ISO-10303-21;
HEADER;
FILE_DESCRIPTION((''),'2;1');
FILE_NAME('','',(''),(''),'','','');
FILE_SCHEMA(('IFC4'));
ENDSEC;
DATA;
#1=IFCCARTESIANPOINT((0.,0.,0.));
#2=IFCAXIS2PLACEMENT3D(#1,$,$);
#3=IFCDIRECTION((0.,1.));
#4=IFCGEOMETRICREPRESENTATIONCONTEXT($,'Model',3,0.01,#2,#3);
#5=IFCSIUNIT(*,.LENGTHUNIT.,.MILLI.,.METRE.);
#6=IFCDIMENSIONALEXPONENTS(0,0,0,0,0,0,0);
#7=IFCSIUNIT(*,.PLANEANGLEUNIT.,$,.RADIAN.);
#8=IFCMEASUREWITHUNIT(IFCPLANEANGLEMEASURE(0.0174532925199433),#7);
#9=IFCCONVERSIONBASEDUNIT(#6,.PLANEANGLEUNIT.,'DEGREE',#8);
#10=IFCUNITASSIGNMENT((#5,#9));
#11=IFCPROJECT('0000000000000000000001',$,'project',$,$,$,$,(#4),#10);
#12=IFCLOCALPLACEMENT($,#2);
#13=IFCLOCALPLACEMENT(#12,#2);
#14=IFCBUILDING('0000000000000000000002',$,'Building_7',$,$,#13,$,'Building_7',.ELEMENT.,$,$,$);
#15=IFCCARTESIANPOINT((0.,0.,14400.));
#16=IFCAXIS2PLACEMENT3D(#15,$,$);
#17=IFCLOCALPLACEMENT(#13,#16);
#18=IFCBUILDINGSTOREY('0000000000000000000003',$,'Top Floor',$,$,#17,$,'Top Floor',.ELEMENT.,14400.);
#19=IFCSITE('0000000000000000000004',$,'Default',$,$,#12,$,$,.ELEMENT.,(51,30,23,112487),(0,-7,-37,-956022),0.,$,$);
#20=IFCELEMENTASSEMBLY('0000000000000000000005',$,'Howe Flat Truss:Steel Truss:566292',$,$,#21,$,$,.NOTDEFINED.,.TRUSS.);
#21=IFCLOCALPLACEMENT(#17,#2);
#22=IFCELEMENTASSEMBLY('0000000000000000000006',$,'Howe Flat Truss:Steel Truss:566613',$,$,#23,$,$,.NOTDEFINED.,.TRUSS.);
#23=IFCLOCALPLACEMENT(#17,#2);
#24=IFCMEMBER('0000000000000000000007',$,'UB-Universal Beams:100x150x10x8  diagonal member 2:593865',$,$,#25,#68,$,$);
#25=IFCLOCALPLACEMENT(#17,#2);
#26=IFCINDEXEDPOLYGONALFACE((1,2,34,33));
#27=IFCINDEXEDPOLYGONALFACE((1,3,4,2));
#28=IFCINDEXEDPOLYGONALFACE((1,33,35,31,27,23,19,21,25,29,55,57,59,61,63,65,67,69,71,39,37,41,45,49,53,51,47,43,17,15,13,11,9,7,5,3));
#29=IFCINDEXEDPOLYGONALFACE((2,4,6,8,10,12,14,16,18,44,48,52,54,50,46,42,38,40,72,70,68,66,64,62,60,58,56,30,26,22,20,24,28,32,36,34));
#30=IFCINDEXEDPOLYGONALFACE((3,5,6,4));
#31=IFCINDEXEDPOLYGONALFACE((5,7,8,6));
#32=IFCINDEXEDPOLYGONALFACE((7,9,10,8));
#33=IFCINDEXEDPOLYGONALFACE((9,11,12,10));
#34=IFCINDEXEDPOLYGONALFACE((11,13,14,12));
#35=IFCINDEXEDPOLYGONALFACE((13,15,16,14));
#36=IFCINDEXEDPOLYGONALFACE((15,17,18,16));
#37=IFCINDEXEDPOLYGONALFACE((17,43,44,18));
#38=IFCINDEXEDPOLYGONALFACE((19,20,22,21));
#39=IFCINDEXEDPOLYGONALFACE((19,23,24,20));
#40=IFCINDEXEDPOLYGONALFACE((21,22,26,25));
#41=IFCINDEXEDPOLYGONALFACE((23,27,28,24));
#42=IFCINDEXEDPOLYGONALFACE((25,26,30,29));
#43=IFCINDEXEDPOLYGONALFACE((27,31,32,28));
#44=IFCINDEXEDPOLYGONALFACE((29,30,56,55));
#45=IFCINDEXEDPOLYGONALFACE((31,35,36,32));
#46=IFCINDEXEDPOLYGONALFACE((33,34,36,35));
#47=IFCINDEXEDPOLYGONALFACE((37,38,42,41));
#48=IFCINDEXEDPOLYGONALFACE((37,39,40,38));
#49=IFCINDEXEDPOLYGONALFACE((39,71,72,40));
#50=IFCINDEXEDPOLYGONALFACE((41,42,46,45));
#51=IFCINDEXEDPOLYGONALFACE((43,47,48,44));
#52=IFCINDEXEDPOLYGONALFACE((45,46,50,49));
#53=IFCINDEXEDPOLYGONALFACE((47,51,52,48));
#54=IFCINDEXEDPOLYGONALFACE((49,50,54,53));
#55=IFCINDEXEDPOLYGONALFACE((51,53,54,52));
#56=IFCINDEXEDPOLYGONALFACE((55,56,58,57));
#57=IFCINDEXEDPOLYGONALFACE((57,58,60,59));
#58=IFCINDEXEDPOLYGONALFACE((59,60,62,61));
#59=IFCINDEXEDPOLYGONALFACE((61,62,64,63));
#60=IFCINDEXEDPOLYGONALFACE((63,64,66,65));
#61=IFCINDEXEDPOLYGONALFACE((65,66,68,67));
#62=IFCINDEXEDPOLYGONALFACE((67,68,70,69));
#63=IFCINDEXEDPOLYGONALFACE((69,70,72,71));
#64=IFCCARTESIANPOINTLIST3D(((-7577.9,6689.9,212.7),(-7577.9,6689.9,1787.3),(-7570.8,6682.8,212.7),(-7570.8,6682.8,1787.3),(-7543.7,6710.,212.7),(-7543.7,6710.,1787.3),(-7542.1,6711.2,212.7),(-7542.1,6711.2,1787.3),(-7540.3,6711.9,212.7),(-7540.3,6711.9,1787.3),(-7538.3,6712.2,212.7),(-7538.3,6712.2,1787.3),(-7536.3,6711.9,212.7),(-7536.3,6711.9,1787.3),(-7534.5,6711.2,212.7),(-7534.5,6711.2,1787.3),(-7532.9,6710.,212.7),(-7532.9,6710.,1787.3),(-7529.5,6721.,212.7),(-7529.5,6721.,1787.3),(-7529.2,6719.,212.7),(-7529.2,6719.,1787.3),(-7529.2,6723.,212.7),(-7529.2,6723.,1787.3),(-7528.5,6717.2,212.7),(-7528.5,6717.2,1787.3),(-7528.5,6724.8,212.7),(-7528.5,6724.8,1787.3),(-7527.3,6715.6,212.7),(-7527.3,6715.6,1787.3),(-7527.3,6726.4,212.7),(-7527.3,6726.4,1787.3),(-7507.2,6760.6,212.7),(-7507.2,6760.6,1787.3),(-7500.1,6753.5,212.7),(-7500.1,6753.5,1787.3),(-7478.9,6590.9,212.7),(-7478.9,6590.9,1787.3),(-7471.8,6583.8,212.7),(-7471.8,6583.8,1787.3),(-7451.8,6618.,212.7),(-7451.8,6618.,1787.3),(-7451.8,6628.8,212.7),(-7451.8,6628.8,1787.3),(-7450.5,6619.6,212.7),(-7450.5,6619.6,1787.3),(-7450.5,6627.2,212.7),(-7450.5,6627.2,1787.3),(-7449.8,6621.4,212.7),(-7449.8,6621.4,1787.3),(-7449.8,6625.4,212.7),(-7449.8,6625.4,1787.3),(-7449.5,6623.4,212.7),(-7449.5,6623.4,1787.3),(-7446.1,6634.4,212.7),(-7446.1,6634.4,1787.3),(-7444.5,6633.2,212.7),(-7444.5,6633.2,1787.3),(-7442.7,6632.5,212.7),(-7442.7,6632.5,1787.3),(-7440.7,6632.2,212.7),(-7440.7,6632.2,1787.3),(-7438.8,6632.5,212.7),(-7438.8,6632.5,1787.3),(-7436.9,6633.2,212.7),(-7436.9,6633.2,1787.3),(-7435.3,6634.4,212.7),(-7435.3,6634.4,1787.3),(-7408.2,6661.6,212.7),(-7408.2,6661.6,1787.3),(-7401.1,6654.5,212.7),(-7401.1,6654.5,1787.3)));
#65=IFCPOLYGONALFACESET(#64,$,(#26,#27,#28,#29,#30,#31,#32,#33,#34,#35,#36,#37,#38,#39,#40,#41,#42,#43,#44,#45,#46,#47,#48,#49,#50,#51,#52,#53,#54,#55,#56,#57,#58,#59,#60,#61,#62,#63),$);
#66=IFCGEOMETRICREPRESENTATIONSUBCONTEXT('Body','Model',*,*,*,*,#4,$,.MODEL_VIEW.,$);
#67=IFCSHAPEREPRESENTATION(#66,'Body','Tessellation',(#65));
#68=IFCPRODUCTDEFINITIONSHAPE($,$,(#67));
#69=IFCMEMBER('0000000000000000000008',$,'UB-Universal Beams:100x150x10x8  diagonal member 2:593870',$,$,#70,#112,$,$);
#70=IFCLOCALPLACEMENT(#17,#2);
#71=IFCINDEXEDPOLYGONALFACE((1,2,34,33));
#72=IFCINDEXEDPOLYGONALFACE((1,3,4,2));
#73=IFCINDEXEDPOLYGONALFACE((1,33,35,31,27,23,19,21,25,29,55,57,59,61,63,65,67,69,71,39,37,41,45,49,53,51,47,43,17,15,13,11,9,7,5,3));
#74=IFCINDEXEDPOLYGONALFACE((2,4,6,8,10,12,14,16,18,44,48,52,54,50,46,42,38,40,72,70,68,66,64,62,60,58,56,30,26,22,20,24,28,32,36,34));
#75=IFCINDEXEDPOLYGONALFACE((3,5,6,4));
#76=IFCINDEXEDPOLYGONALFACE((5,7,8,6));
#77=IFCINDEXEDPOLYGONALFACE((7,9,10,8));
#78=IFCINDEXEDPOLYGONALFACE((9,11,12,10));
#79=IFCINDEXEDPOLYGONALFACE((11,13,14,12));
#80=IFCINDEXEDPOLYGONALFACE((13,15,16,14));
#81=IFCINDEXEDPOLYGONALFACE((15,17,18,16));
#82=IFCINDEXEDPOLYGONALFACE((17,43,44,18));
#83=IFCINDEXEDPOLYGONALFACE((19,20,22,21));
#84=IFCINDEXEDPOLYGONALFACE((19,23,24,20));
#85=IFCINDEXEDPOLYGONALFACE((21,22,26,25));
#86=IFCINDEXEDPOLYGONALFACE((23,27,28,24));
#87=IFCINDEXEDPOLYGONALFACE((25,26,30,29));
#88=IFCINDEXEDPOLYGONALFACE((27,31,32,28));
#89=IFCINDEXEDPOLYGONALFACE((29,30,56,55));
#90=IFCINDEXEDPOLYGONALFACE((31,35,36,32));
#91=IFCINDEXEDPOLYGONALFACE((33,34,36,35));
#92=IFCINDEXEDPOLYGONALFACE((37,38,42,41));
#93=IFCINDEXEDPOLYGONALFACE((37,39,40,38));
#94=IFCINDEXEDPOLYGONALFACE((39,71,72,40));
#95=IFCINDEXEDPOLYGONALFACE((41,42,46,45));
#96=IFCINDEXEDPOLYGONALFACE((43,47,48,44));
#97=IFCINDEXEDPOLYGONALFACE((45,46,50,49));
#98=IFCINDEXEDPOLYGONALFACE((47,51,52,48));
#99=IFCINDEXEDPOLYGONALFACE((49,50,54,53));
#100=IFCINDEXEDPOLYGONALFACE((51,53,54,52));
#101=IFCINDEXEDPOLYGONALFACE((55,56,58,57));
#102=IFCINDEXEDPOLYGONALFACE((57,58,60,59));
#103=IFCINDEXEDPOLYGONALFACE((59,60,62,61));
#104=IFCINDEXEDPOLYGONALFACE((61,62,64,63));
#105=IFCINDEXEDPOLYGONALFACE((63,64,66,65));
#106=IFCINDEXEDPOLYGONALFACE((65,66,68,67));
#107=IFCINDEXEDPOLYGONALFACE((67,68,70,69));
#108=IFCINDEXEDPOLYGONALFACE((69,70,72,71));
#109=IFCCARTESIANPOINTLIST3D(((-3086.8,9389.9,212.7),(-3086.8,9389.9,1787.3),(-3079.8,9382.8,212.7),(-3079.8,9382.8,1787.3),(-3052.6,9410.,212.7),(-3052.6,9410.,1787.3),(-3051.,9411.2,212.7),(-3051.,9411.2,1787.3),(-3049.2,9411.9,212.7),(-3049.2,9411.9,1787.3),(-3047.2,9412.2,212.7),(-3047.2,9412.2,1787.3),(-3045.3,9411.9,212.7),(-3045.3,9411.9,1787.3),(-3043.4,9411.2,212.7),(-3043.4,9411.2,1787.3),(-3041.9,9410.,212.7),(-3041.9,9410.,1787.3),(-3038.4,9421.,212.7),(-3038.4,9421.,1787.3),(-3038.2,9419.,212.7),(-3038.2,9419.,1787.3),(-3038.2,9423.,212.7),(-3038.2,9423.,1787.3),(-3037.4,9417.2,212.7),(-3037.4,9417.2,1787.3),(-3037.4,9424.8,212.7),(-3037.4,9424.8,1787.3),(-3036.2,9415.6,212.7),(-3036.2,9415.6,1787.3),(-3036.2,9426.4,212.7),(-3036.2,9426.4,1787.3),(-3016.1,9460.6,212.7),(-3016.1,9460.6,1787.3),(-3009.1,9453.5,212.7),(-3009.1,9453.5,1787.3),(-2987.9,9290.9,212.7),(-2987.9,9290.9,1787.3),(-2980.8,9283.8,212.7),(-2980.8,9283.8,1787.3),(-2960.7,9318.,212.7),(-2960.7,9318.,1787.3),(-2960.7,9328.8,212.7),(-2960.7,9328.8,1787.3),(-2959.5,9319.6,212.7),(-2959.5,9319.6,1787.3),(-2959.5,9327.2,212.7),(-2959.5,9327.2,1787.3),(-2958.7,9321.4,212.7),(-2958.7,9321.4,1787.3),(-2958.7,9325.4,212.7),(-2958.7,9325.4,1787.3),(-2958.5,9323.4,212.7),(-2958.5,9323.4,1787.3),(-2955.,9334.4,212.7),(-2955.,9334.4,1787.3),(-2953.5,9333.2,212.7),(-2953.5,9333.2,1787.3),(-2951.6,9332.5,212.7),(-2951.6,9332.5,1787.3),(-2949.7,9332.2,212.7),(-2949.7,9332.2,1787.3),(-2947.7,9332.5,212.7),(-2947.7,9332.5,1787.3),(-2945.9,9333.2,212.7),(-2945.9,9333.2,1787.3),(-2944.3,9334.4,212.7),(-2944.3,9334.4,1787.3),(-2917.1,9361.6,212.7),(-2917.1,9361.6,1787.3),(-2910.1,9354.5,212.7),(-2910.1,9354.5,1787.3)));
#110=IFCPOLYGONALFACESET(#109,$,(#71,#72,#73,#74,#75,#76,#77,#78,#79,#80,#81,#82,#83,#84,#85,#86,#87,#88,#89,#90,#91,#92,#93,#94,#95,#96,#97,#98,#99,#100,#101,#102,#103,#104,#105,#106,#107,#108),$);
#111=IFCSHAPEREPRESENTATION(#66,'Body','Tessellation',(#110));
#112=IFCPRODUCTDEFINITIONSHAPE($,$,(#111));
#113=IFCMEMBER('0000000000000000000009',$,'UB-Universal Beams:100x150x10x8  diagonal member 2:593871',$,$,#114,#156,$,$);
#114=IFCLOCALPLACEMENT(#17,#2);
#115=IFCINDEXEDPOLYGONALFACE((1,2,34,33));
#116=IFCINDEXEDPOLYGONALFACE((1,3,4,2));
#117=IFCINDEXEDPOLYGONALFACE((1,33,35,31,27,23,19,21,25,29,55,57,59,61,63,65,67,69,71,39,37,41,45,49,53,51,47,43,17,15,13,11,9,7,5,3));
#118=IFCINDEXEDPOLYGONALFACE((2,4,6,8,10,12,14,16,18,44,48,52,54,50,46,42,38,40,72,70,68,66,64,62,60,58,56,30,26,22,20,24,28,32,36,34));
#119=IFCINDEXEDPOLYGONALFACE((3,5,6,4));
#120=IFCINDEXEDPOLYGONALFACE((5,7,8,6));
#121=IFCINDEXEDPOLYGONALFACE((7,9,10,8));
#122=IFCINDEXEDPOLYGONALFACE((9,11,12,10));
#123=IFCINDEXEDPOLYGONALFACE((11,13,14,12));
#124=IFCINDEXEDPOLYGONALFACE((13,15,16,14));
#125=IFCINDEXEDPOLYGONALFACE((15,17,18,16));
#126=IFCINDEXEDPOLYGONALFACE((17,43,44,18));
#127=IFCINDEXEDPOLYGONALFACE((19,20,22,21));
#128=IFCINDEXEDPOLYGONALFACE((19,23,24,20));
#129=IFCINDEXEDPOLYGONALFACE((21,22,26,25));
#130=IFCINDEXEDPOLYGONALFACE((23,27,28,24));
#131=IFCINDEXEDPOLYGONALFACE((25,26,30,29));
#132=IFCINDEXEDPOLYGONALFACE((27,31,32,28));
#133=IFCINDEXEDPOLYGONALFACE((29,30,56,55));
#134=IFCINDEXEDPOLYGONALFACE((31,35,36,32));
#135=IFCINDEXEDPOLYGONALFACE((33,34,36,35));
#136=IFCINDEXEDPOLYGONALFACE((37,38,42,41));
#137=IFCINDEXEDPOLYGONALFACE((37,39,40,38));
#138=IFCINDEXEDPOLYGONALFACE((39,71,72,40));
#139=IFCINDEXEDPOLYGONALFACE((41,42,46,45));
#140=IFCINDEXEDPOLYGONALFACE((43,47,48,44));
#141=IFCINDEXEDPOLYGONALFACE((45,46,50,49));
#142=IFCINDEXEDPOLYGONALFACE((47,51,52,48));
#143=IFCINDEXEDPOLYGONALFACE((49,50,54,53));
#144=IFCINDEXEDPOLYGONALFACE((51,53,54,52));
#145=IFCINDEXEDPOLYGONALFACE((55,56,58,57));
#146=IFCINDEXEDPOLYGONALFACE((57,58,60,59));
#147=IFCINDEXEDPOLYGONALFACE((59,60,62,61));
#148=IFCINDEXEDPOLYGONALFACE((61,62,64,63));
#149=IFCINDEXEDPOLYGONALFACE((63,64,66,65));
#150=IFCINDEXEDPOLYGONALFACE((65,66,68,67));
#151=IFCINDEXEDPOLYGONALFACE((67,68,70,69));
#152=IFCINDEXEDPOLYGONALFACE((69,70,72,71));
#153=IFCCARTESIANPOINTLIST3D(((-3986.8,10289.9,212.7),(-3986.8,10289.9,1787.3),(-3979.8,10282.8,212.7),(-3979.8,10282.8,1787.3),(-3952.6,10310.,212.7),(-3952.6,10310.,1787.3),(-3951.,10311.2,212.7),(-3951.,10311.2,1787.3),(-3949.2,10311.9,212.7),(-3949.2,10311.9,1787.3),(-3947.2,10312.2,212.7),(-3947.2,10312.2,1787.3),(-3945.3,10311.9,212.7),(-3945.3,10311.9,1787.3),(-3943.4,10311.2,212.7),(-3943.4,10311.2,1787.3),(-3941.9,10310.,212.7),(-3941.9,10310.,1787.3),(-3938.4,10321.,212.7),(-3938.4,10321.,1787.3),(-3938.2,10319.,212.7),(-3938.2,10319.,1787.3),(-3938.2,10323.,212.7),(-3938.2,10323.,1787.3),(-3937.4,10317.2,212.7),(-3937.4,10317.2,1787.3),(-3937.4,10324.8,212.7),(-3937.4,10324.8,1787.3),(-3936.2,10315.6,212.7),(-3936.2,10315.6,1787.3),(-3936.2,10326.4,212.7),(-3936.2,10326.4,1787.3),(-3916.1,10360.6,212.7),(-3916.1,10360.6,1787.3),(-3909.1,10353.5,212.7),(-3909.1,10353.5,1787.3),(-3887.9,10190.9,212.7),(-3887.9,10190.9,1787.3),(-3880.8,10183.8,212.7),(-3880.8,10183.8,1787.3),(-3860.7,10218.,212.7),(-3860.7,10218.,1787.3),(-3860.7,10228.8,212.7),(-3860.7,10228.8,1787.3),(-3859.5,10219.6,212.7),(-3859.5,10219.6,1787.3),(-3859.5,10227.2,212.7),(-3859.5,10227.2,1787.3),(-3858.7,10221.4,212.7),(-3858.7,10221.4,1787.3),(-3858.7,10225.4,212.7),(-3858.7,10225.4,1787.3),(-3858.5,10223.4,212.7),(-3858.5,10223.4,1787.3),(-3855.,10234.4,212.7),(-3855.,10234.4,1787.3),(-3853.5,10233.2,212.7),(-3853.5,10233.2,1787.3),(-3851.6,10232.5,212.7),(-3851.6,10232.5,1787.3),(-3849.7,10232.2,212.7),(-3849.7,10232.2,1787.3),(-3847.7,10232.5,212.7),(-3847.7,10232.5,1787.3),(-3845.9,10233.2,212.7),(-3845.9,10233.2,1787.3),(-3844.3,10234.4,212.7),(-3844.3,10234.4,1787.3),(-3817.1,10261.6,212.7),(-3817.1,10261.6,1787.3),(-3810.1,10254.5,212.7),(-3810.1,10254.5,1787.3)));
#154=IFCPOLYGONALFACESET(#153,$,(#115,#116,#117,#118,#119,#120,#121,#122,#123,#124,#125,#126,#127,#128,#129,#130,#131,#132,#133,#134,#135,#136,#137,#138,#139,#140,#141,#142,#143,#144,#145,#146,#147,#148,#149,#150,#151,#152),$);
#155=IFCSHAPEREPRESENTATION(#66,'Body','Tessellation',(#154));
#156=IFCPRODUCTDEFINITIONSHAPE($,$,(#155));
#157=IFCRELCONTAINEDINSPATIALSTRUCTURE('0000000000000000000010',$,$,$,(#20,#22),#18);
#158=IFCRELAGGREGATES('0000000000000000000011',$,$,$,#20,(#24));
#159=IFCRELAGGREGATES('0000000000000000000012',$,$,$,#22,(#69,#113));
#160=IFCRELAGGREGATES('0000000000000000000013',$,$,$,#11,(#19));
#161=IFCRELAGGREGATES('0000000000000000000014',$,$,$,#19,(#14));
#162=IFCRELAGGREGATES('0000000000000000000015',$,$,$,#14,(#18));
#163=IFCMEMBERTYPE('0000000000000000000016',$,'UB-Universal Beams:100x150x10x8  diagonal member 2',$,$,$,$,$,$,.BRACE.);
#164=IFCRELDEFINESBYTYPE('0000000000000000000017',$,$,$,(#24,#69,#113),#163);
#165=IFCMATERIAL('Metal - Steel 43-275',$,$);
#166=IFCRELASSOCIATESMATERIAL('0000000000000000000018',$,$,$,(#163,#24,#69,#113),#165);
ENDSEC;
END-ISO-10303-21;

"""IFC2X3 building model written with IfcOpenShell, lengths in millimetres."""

from ifc_helpers import new_model, entity, si_unit, converted_unit, direction, frame, frame_2d, origin, place, context, subcontext, project, spatial, polyline, circle_curve, parameter, trimmed, segment, composite_curve, outline, extrude, source, transform, mapped, material, type_object, type_shapes, element, aggregate, save


model = new_model("IFC2X3")

# Units and contexts
model_context = context("Model", 3, precision=0.01, world=origin(), true_north=direction((0.0, 1.0)))
body_context = subcontext(model_context, "Body", "Model", "MODEL_VIEW")
ifc_project = project(units=[si_unit("LENGTHUNIT", "METRE", prefix="MILLI"), converted_unit("PLANEANGLEUNIT", "DEGREE", entity("IfcPlaneAngleMeasure", 0.0174532925199433), si_unit("PLANEANGLEUNIT", "RADIAN"), dimensions=[0, 0, 0, 0, 0, 0, 0])], contexts=[model_context])

# Site, building, storey
site_placement = place(None, origin())
site = spatial("IfcSite", under=ifc_project, at=site_placement, Name="Default", CompositionType="ELEMENT", RefLatitude=(51, 30, 23, 112487), RefLongitude=(0, -7, -37, -956022), RefElevation=0.0)
building_placement = place(site_placement, origin())
building = spatial("IfcBuilding", under=site, at=building_placement, Name="Building_7", LongName="Building_7", CompositionType="ELEMENT")
storey_placement = place(building_placement, frame((0.0, 0.0, 14400.0)))
storey = spatial("IfcBuildingStorey", under=building, at=storey_placement, Name="Top Floor", LongName="Top Floor", CompositionType="ELEMENT", Elevation=14400.0)

# Shared definitions
ifc_material = material(Name="Metal - Steel 43-275")

# Element assembly
assembly_1_placement = place(storey_placement, origin())
assembly_1 = element("IfcElementAssembly", 1, at=assembly_1_placement, inside=storey, Name="Howe Flat Truss:Steel Truss:566292", AssemblyPlace="NOTDEFINED", PredefinedType="TRUSS")
member_type_1 = type_object("IfcMemberType", Name="UB-Universal Beams:100x150x10x8  diagonal member 2", PredefinedType="BRACE", material=ifc_material)
shared_shape_1 = source(origin(), body_context, "Body", "SweptSolid", [
    extrude(outline(composite_curve([segment(polyline([(-50.0, -65.0), (-50.0, -75.0)]), True, "CONTINUOUS"), segment(polyline([(-50.0, -75.0), (50.0, -75.0)]), True, "CONTINUOUS"), segment(polyline([(50.0, -75.0), (50.0, -65.0)]), True, "CONTINUOUS"), segment(polyline([(50.0, -65.0), (11.6, -65.0)]), True, "CONTINUOUS"), segment(trimmed(circle_curve(frame_2d((11.6, -57.4), x_axis=(1.0, 0.0)), 7.6), [parameter(180.0)], [parameter(270.0)], True, "PARAMETER"), False, "CONTINUOUS"), segment(polyline([(4.0, -57.4), (4.0, 57.4)]), True, "CONTINUOUS"), segment(trimmed(circle_curve(frame_2d((11.6, 57.4), x_axis=(1.0, 0.0)), 7.6), [parameter(90.0)], [parameter(180.0)], True, "PARAMETER"), False, "CONTINUOUS"), segment(polyline([(11.6, 65.0), (50.0, 65.0)]), True, "CONTINUOUS"), segment(polyline([(50.0, 65.0), (50.0, 75.0)]), True, "CONTINUOUS"), segment(polyline([(50.0, 75.0), (-50.0, 75.0)]), True, "CONTINUOUS"), segment(polyline([(-50.0, 75.0), (-50.0, 65.0)]), True, "CONTINUOUS"), segment(polyline([(-50.0, 65.0), (-11.6, 65.0)]), True, "CONTINUOUS"), segment(trimmed(circle_curve(frame_2d((-11.6, 57.4), x_axis=(1.0, 0.0)), 7.6), [parameter(360.0)], [parameter(90.0)], True, "PARAMETER"), False, "CONTINUOUS"), segment(polyline([(-4.0, 57.4), (-4.0, -57.4)]), True, "CONTINUOUS"), segment(trimmed(circle_curve(frame_2d((-11.6, -57.4), x_axis=(1.0, 0.0)), 7.6), [parameter(270.0)], [parameter(360.0)], True, "PARAMETER"), False, "CONTINUOUS"), segment(polyline([(-11.6, -65.0), (-50.0, -65.0)]), True, "CONTINUOUS")], self_intersect=False)), frame((-787.3, 0.0, 0.0), z_axis=(-1.0, 0.0, 0.0), x_axis=(0.0, -1.0, 0.0)), (0.0, 0.0, -1.0), 1574.6),
])
type_shapes(member_type_1, [shared_shape_1])

# Element assembly
assembly_2_placement = place(storey_placement, origin())
assembly_2 = element("IfcElementAssembly", 2, at=assembly_2_placement, inside=storey, Name="Howe Flat Truss:Steel Truss:566613", AssemblyPlace="NOTDEFINED", PredefinedType="TRUSS")

# Members
member_1_placement = place(assembly_1_placement, frame((-7489.5, 6672.2, 1000.0), z_axis=(-0.707107, 0.707107, 0.0), x_axis=(0.0, 0.0, 1.0)))
member_1 = element("IfcMember", 3, at=member_1_placement, type_object=member_type_1, material=ifc_material, Name="UB-Universal Beams:100x150x10x8  diagonal member 2:593865", context=body_context, shape_type="MappedRepresentation", body=[
    mapped(shared_shape_1, transform((0.0, 0.0, 0.0), scale=1.0)),
])
member_2_placement = place(assembly_2_placement, frame((-2998.5, 9372.2, 1000.0), z_axis=(0.707107, -0.707107, 0.0), x_axis=(0.0, 0.0, 1.0)))
member_2 = element("IfcMember", 4, at=member_2_placement, type_object=member_type_1, material=ifc_material, Name="UB-Universal Beams:100x150x10x8  diagonal member 2:593870", context=body_context, shape_type="MappedRepresentation", body=[
    mapped(shared_shape_1, transform((0.0, 0.0, 0.0), scale=1.0)),
])
member_3_placement = place(assembly_2_placement, frame((-3898.5, 10272.2, 1000.0), z_axis=(0.707107, -0.707107, 0.0), x_axis=(0.0, 0.0, 1.0)))
member_3 = element("IfcMember", 5, at=member_3_placement, type_object=member_type_1, material=ifc_material, Name="UB-Universal Beams:100x150x10x8  diagonal member 2:593871", context=body_context, shape_type="MappedRepresentation", body=[
    mapped(shared_shape_1, transform((0.0, 0.0, 0.0), scale=1.0)),
])
aggregate(assembly_1, [member_1])
aggregate(assembly_2, [member_2, member_3])

save(model, "model.ifc")
